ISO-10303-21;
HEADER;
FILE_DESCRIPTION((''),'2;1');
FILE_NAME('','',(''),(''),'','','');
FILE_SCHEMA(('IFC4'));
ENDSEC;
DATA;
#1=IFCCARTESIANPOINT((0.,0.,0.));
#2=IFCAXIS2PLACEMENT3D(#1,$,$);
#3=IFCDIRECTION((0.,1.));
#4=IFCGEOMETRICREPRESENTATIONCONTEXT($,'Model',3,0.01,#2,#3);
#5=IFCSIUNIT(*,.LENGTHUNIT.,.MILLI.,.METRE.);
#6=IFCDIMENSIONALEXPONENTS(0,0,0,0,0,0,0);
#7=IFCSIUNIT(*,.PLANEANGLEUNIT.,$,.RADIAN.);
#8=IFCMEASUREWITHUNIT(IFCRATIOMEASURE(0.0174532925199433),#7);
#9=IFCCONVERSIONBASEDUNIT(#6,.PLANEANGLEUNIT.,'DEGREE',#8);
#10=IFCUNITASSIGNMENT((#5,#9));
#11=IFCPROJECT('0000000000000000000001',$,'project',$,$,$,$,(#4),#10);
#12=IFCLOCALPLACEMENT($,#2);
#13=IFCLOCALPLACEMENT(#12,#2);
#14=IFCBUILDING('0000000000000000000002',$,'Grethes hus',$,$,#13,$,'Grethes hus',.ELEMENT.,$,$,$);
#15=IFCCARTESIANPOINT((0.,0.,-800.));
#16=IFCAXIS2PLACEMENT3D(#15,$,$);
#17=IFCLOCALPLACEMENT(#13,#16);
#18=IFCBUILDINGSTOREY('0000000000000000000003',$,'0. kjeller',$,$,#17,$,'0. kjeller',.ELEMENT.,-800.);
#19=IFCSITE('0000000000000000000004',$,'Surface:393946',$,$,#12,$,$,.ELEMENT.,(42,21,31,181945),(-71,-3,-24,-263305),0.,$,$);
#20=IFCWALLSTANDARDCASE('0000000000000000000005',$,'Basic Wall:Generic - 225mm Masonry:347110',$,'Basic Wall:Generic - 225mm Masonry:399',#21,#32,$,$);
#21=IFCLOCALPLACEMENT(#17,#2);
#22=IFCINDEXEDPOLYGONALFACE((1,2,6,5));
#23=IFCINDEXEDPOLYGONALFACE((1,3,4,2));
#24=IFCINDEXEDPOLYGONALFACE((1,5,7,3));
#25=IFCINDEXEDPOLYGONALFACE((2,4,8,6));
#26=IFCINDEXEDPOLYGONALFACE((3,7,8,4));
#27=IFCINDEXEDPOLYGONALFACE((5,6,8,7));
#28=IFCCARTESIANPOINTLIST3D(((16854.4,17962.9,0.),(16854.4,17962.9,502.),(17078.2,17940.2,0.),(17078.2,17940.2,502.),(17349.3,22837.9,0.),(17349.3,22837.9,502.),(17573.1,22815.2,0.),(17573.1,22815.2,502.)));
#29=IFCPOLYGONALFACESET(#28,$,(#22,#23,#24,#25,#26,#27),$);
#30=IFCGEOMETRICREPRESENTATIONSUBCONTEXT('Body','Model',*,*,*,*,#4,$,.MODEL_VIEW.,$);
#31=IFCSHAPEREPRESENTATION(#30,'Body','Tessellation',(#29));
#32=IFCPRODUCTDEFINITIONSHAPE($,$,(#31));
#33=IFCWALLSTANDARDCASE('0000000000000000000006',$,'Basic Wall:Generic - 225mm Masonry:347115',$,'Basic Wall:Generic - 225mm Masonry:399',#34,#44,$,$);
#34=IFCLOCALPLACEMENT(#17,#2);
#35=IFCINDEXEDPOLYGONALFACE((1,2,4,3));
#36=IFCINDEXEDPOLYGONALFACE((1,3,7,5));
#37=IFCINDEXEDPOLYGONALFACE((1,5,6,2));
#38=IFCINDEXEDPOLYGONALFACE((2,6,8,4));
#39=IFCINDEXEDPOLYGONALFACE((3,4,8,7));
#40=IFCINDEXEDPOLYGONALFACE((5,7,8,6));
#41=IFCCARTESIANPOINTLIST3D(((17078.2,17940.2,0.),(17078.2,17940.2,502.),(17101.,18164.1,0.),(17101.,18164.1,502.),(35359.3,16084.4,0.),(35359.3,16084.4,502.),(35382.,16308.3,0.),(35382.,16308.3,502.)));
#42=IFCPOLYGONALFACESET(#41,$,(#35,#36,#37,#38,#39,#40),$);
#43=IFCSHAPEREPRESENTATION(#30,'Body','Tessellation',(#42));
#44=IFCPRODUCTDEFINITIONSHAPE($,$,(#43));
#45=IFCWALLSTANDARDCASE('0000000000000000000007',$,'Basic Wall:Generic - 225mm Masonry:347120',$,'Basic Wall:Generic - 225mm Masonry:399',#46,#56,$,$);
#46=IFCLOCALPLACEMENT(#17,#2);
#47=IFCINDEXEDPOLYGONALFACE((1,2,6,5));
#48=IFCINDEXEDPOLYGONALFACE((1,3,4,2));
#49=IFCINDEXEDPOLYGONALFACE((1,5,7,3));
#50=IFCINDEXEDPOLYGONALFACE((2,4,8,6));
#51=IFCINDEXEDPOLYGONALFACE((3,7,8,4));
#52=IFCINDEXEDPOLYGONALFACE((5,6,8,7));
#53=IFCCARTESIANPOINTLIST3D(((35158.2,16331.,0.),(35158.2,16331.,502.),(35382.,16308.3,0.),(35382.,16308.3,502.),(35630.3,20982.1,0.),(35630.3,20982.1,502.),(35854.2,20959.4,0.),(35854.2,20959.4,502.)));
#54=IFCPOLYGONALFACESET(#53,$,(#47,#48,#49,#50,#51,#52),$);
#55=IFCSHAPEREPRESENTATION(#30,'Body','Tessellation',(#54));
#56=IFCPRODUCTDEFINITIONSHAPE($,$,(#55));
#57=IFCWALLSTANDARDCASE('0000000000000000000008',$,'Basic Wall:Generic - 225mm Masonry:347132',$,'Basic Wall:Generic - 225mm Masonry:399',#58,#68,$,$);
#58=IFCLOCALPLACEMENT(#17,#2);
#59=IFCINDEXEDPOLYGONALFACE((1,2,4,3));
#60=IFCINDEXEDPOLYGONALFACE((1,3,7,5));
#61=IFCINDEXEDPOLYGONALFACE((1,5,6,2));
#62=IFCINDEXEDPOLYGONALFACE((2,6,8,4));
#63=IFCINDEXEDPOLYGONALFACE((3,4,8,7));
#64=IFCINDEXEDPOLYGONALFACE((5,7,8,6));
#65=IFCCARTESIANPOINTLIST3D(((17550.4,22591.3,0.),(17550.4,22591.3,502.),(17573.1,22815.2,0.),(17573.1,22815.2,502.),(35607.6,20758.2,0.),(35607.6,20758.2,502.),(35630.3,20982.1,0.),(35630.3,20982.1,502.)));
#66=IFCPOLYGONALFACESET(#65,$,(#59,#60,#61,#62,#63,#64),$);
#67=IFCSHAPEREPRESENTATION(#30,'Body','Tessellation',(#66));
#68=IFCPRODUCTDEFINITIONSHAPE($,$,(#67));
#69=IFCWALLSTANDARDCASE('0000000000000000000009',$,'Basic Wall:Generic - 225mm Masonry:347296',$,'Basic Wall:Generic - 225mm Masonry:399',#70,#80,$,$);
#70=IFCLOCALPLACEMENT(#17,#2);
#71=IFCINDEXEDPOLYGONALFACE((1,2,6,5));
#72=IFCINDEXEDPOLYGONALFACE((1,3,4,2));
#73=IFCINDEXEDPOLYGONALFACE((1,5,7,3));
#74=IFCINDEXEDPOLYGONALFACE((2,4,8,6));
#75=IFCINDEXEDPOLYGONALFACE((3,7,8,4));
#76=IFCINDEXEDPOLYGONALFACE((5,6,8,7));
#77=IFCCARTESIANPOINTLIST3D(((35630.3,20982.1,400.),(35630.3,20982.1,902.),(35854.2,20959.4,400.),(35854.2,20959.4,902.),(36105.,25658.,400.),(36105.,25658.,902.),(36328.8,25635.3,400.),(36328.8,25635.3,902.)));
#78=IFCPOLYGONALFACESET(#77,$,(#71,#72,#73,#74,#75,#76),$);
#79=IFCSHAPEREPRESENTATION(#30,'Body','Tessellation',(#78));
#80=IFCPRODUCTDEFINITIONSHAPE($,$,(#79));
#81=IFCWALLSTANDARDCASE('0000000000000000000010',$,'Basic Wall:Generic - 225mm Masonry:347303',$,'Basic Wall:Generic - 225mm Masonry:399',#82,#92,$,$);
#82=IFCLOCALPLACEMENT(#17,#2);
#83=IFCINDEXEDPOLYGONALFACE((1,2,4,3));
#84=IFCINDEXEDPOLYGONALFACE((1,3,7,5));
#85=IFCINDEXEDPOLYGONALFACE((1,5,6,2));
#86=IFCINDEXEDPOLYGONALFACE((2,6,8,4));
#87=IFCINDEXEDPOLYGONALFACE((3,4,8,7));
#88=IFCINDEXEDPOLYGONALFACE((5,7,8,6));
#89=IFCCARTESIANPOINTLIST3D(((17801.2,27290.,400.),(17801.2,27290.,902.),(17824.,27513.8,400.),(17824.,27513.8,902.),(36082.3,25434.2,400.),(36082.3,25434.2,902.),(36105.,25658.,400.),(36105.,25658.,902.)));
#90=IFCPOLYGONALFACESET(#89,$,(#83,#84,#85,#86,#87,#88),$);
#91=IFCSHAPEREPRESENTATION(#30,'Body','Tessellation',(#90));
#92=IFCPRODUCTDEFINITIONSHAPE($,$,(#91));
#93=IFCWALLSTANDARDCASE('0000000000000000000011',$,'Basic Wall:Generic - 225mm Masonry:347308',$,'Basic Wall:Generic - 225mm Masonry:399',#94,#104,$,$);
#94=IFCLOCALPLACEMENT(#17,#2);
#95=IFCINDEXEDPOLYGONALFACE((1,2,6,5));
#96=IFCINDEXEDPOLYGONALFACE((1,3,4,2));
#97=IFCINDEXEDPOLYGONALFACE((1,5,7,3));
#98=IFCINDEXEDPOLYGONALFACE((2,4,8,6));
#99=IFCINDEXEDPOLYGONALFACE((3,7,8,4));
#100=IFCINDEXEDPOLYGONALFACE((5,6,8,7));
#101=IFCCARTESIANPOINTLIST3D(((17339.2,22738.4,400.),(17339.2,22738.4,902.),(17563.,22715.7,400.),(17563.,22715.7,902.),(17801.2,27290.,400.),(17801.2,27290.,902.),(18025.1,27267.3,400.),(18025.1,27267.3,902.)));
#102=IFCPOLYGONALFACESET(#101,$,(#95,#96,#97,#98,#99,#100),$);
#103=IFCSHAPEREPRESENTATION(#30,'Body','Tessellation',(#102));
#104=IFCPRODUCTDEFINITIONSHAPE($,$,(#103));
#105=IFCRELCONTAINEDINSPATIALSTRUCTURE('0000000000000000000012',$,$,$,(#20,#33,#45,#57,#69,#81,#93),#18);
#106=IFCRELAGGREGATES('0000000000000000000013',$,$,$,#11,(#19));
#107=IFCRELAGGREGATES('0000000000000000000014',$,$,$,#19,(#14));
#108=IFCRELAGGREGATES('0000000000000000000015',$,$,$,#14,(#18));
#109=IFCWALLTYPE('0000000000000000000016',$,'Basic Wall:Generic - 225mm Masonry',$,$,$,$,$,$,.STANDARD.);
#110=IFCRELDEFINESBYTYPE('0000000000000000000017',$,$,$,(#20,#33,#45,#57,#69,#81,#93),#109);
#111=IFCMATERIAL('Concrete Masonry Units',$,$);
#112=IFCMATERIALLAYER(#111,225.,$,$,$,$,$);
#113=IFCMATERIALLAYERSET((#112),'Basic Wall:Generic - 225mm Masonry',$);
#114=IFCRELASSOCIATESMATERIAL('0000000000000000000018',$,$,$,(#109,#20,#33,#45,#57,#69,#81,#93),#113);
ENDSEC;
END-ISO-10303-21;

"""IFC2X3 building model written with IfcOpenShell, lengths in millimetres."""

from ifc_helpers import new_model, entity, si_unit, converted_unit, direction, frame, frame_2d, origin, place, context, subcontext, project, spatial, rectangle, extrude, material, layer, layer_set, layer_usage, type_object, element, save


model = new_model("IFC2X3")

# Units and contexts
model_context = context("Model", 3, precision=0.01, world=origin(), true_north=direction((0.0, 1.0)))
body_context = subcontext(model_context, "Body", "Model", "MODEL_VIEW")
ifc_project = project(units=[si_unit("LENGTHUNIT", "METRE", prefix="MILLI"), converted_unit("PLANEANGLEUNIT", "DEGREE", entity("IfcRatioMeasure", 0.0174532925199433), si_unit("PLANEANGLEUNIT", "RADIAN"), dimensions=[0, 0, 0, 0, 0, 0, 0])], contexts=[model_context])

# Site, building, storey
site_placement = place(None, origin())
site = spatial("IfcSite", under=ifc_project, at=site_placement, Name="Surface:393946", CompositionType="ELEMENT", RefLatitude=(42, 21, 31, 181945), RefLongitude=(-71, -3, -24, -263305), RefElevation=0.0)
building_placement = place(site_placement, origin())
building = spatial("IfcBuilding", under=site, at=building_placement, Name="Grethes hus", LongName="Grethes hus", CompositionType="ELEMENT")
storey_placement = place(building_placement, frame((0.0, 0.0, -800.0)))
storey = spatial("IfcBuildingStorey", under=building, at=storey_placement, Name="0. kjeller", LongName="0. kjeller", CompositionType="ELEMENT", Elevation=-800.0)

# Walls
ifc_material = material(Name="Concrete Masonry Units")
ifc_layer = layer(ifc_material, 225.0)
ifc_layer_set = layer_set([ifc_layer], Name="Basic Wall:Generic - 225mm Masonry")
ifc_layer_usage_1 = layer_usage(ifc_layer_set, "AXIS2", "NEGATIVE", 112.5)
wall_type = type_object("IfcWallType", Name="Basic Wall:Generic - 225mm Masonry", PredefinedType="STANDARD", material=ifc_layer_set)
wall_1_placement = place(storey_placement, frame((17461.2, 22826.5, 0.0), z_axis=(0.0, 0.0, 1.0), x_axis=(-0.100996, -0.994887, 0.0)))
element("IfcWallStandardCase", 1, at=wall_1_placement, inside=storey, type_object=wall_type, material=ifc_layer_usage_1, Name="Basic Wall:Generic - 225mm Masonry:347110", ObjectType="Basic Wall:Generic - 225mm Masonry:399", context=body_context, shape_type="SweptSolid", body=[
    extrude(rectangle(XDim=4900.0, YDim=225.0, at=frame_2d((2450.0, 0.0), x_axis=(-1.0, 0.0))), origin(), (0.0, 0.0, 1.0), 502.0),
])
ifc_layer_usage_2 = layer_usage(ifc_layer_set, "AXIS2", "NEGATIVE", 112.5)
wall_2_placement = place(storey_placement, frame((17089.6, 18052.1, 0.0), z_axis=(0.0, 0.0, 1.0), x_axis=(0.994887, -0.100996, 0.0)))
element("IfcWallStandardCase", 2, at=wall_2_placement, inside=storey, type_object=wall_type, material=ifc_layer_usage_2, Name="Basic Wall:Generic - 225mm Masonry:347115", ObjectType="Basic Wall:Generic - 225mm Masonry:399", context=body_context, shape_type="SweptSolid", body=[
    extrude(rectangle(XDim=18375.0, YDim=225.0, at=frame_2d((9187.5, 0.0), x_axis=(-1.0, 0.0))), origin(), (0.0, 0.0, 1.0), 502.0),
])
ifc_layer_usage_3 = layer_usage(ifc_layer_set, "AXIS2", "NEGATIVE", 112.5)
wall_3_placement = place(storey_placement, frame((35270.1, 16319.6, 0.0), z_axis=(0.0, 0.0, 1.0), x_axis=(0.100996, 0.994887, 0.0)))
element("IfcWallStandardCase", 3, at=wall_3_placement, inside=storey, type_object=wall_type, material=ifc_layer_usage_3, Name="Basic Wall:Generic - 225mm Masonry:347120", ObjectType="Basic Wall:Generic - 225mm Masonry:399", context=body_context, shape_type="SweptSolid", body=[
    extrude(rectangle(XDim=4675.0, YDim=225.0, at=frame_2d((2337.5, 0.0), x_axis=(-1.0, 0.0))), origin(), (0.0, 0.0, 1.0), 502.0),
])
ifc_layer_usage_4 = layer_usage(ifc_layer_set, "AXIS2", "NEGATIVE", 112.5)
wall_4_placement = place(storey_placement, frame((17561.8, 22703.2, 0.0), z_axis=(0.0, 0.0, 1.0), x_axis=(0.994887, -0.100996, 0.0)))
element("IfcWallStandardCase", 4, at=wall_4_placement, inside=storey, type_object=wall_type, material=ifc_layer_usage_4, Name="Basic Wall:Generic - 225mm Masonry:347132", ObjectType="Basic Wall:Generic - 225mm Masonry:399", context=body_context, shape_type="SweptSolid", body=[
    extrude(rectangle(XDim=18150.0, YDim=225.0, at=frame_2d((9075.0, 0.0), x_axis=(-1.0, 0.0))), origin(), (0.0, 0.0, 1.0), 502.0),
])
ifc_layer_usage_5 = layer_usage(ifc_layer_set, "AXIS2", "NEGATIVE", 112.5)
wall_5_placement = place(storey_placement, frame((35742.2, 20970.7, 400.0), z_axis=(0.0, 0.0, 1.0), x_axis=(0.100996, 0.994887, 0.0)))
element("IfcWallStandardCase", 5, at=wall_5_placement, inside=storey, type_object=wall_type, material=ifc_layer_usage_5, Name="Basic Wall:Generic - 225mm Masonry:347296", ObjectType="Basic Wall:Generic - 225mm Masonry:399", context=body_context, shape_type="SweptSolid", body=[
    extrude(rectangle(XDim=4700.0, YDim=225.0, at=frame_2d((2350.0, 0.0), x_axis=(-1.0, 0.0))), origin(), (0.0, 0.0, 1.0), 502.0),
])
ifc_layer_usage_6 = layer_usage(ifc_layer_set, "AXIS2", "NEGATIVE", 112.5)
wall_6_placement = place(storey_placement, frame((36093.6, 25546.1, 400.0), z_axis=(0.0, 0.0, 1.0), x_axis=(-0.994887, 0.100996, 0.0)))
element("IfcWallStandardCase", 6, at=wall_6_placement, inside=storey, type_object=wall_type, material=ifc_layer_usage_6, Name="Basic Wall:Generic - 225mm Masonry:347303", ObjectType="Basic Wall:Generic - 225mm Masonry:399", context=body_context, shape_type="SweptSolid", body=[
    extrude(rectangle(XDim=18375.0, YDim=225.0, at=frame_2d((9187.5, 0.0), x_axis=(-1.0, 0.0))), origin(), (0.0, 0.0, 1.0), 502.0),
])
ifc_layer_usage_7 = layer_usage(ifc_layer_set, "AXIS2", "NEGATIVE", 112.5)
wall_7_placement = place(storey_placement, frame((17913.2, 27278.6, 400.0), z_axis=(0.0, 0.0, 1.0), x_axis=(-0.100996, -0.994887, 0.0)))
element("IfcWallStandardCase", 7, at=wall_7_placement, inside=storey, type_object=wall_type, material=ifc_layer_usage_7, Name="Basic Wall:Generic - 225mm Masonry:347308", ObjectType="Basic Wall:Generic - 225mm Masonry:399", context=body_context, shape_type="SweptSolid", body=[
    extrude(rectangle(XDim=4575.0, YDim=225.0, at=frame_2d((2287.5, 0.0), x_axis=(-1.0, 0.0))), origin(), (0.0, 0.0, 1.0), 502.0),
])

save(model, "model.ifc")
